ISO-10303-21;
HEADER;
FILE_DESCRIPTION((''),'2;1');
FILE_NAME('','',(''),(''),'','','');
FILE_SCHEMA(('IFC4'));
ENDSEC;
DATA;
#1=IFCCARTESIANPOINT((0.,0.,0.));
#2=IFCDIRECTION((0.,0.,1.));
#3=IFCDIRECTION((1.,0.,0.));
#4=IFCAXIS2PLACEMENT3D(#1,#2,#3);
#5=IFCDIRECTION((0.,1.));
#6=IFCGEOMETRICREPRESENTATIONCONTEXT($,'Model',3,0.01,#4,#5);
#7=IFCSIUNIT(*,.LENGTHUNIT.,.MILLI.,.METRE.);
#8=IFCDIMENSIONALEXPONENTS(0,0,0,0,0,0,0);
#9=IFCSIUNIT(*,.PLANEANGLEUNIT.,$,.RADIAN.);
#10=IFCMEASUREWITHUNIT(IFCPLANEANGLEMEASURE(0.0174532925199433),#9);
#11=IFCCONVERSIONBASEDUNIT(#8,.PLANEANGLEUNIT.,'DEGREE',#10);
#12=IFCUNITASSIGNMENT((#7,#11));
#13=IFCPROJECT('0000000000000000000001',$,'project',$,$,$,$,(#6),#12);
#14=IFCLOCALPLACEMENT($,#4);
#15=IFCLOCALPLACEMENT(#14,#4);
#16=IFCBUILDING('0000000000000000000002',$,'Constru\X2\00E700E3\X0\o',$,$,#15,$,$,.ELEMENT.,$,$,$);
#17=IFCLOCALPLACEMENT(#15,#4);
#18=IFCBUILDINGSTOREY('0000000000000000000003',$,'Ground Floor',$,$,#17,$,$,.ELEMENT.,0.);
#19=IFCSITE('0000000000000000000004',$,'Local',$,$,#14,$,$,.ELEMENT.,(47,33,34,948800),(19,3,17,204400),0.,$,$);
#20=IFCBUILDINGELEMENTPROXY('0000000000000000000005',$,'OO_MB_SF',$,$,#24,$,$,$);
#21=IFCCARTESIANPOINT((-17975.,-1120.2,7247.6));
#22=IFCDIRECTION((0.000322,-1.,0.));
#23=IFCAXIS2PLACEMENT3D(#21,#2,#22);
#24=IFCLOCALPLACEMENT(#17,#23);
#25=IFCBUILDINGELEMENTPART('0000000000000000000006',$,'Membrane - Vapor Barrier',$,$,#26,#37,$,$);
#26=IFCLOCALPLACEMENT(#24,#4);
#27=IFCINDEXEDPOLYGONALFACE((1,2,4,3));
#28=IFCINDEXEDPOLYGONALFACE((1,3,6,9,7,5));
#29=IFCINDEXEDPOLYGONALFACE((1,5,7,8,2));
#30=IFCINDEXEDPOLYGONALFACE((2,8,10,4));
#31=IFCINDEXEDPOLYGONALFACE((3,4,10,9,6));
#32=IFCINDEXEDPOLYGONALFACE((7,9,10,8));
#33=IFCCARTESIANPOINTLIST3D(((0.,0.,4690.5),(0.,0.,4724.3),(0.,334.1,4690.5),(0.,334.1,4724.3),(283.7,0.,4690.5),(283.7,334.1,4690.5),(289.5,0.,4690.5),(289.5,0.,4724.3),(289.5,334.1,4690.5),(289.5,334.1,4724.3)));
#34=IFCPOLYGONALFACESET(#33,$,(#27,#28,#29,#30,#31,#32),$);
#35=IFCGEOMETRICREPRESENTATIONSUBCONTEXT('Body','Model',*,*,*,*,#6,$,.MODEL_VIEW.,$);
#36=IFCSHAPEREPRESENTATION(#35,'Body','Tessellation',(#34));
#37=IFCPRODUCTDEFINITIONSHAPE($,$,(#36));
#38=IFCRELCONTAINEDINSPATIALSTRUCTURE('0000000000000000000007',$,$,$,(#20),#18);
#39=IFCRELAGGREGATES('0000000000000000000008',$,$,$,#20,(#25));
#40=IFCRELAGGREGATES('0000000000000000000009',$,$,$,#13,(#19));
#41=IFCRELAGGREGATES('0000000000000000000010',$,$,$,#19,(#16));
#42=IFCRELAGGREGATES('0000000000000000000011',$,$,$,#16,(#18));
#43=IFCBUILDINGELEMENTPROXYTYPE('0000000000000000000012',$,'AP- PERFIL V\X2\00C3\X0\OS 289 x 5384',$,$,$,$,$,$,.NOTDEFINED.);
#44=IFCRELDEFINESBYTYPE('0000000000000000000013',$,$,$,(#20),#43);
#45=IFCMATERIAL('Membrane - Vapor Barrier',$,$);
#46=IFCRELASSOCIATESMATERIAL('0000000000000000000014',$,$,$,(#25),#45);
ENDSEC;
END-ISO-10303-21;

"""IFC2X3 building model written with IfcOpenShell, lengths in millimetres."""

from ifc_helpers import new_model, entity, si_unit, converted_unit, direction, frame, origin_with_axes, place, context, subcontext, project, spatial, polyline, outline, extrude, material, type_object, element, aggregate, save


model = new_model("IFC2X3")

# Units and contexts
model_context = context("Model", 3, precision=0.01, world=origin_with_axes(), true_north=direction((0.0, 1.0)))
body_context = subcontext(model_context, "Body", "Model", "MODEL_VIEW")
ifc_project = project(units=[si_unit("LENGTHUNIT", "METRE", prefix="MILLI"), converted_unit("PLANEANGLEUNIT", "DEGREE", entity("IfcPlaneAngleMeasure", 0.0174532925199433), si_unit("PLANEANGLEUNIT", "RADIAN"), dimensions=[0, 0, 0, 0, 0, 0, 0])], contexts=[model_context])

# Site, building, storey
site_placement = place(None, origin_with_axes())
site = spatial("IfcSite", under=ifc_project, at=site_placement, Name="Local", CompositionType="ELEMENT", RefLatitude=(47, 33, 34, 948800), RefLongitude=(19, 3, 17, 204400), RefElevation=0.0)
building_placement = place(site_placement, origin_with_axes())
building = spatial("IfcBuilding", under=site, at=building_placement, Name="Construção", CompositionType="ELEMENT")
storey_placement = place(building_placement, origin_with_axes())
storey = spatial("IfcBuildingStorey", under=building, at=storey_placement, Name="Ground Floor", CompositionType="ELEMENT", Elevation=0.0)

# Building element proxy, building element part
building_element_proxy_type = type_object("IfcBuildingElementProxyType", Name="AP- PERFIL VÃOS 289 x 5384", PredefinedType="NOTDEFINED")
ifc_material = material(Name="Membrane - Vapor Barrier")
proxy_1_placement = place(storey_placement, frame((-17975.0, -1120.2, 7247.6), z_axis=(0.0, 0.0, 1.0), x_axis=(0.000322, -1.0, 0.0)))
proxy_1 = element("IfcBuildingElementProxy", 1, at=proxy_1_placement, inside=storey, type_object=building_element_proxy_type, Name="OO_MB_SF")
building_element_part_1_placement = place(proxy_1_placement, origin_with_axes())
building_element_part_1 = element("IfcBuildingElementPart", 2, at=building_element_part_1_placement, material=ifc_material, Name="Membrane - Vapor Barrier", context=body_context, shape_type="SweptSolid", body=[
    extrude(outline(polyline([(0.0, 4690.5), (283.7, 4690.5), (289.5, 4690.5), (289.5, 4724.3), (0.0, 4724.3), (0.0, 4690.5)])), frame((0.0, 334.1, 0.0), z_axis=(0.0, -1.0, 0.0), x_axis=(1.0, 0.0, 0.0)), (0.0, 0.0, 1.0), 334.1),
])
aggregate(proxy_1, [building_element_part_1])

save(model, "model.ifc")
